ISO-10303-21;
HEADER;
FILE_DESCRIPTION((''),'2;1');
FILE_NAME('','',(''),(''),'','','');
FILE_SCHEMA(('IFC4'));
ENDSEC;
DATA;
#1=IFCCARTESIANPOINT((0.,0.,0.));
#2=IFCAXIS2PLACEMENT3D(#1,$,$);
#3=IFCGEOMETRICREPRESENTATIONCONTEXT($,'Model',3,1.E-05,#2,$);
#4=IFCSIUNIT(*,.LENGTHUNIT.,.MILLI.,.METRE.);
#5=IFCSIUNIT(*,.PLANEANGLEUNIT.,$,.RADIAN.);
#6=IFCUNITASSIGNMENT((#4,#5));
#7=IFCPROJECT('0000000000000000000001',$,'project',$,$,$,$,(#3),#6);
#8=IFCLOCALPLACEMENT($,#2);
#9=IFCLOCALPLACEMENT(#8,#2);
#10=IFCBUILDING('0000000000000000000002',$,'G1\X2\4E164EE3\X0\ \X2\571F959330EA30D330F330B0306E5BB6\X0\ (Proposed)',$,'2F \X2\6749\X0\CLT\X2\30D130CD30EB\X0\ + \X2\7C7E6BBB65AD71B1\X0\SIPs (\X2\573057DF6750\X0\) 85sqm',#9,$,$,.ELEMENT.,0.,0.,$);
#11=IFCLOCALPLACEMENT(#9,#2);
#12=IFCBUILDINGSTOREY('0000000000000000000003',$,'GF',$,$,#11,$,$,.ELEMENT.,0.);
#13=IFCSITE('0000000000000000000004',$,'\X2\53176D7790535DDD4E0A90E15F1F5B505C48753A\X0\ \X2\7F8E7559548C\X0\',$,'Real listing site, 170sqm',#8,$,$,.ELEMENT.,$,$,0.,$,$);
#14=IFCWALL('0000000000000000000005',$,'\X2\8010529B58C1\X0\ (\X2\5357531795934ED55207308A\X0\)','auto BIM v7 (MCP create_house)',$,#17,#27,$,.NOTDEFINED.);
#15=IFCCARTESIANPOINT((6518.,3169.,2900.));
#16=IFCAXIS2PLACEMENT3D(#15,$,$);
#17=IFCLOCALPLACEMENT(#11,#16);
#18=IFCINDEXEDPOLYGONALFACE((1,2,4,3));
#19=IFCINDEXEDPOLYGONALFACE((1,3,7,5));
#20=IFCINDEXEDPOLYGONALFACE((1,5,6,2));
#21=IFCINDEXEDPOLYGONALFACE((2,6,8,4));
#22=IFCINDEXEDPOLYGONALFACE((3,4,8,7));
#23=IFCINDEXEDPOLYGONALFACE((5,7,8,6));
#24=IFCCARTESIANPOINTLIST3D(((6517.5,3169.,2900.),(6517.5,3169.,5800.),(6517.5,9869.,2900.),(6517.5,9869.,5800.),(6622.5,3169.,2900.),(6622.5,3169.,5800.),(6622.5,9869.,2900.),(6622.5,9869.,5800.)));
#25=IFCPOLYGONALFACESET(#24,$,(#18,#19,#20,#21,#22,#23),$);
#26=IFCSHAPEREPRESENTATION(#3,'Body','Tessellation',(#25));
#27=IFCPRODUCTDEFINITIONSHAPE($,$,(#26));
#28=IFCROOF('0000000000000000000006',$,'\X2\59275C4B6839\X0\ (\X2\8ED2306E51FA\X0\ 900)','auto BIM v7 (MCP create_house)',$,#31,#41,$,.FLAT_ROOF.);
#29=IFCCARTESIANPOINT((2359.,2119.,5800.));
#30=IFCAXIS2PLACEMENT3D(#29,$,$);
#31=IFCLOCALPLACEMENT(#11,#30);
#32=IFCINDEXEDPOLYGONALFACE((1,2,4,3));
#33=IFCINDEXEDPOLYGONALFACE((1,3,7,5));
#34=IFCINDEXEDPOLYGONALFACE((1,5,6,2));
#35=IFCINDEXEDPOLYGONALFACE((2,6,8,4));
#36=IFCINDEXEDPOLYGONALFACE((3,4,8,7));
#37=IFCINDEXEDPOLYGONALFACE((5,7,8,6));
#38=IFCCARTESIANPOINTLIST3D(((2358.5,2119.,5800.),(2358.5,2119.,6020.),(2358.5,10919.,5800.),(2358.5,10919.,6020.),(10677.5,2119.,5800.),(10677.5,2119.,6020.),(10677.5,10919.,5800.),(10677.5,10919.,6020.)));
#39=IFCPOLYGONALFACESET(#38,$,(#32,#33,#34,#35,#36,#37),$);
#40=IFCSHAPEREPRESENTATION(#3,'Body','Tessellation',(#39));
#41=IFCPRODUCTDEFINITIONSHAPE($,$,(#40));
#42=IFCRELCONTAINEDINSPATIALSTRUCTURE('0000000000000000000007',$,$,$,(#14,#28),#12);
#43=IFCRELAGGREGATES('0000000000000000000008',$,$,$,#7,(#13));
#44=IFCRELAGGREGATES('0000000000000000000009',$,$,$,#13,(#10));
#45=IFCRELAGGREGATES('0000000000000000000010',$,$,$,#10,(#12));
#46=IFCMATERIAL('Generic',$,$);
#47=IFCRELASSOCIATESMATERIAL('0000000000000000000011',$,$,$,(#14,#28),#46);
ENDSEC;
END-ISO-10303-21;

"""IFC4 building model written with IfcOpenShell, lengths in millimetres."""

from ifc_helpers import new_model, si_unit, frame, frame_2d, origin, place, context, project, spatial, rectangle, extrude, material, element, save


model = new_model("IFC4")

# Units and contexts
model_context = context("Model", 3, precision=1e-05, world=origin())
ifc_project = project(units=[si_unit("LENGTHUNIT", "METRE", prefix="MILLI"), si_unit("PLANEANGLEUNIT", "RADIAN")], contexts=[model_context])

# Site, building, storey
site_placement = place(None, origin())
site = spatial("IfcSite", under=ifc_project, at=site_placement, Name="北海道川上郡弟子屈町 美留和", ObjectType="Real listing site, 170sqm", CompositionType="ELEMENT", RefElevation=0.0)
building_placement = place(site_placement, origin())
building = spatial("IfcBuilding", under=site, at=building_placement, Name="G1世代 土間リビングの家 (Proposed)", ObjectType="2F 杉CLTパネル + 籾殻断熱SIPs (地域材) 85sqm", CompositionType="ELEMENT", ElevationOfRefHeight=0.0, ElevationOfTerrain=0.0)
storey_placement = place(building_placement, origin())
storey = spatial("IfcBuildingStorey", under=building, at=storey_placement, Name="GF", CompositionType="ELEMENT", Elevation=0.0)

# Shared definitions
ifc_material = material(Name="Generic")

# Wall
wall_1_placement = place(storey_placement, frame((6518.0, 3169.0, 2900.0)))
element("IfcWall", 1, at=wall_1_placement, inside=storey, material=ifc_material, Name="耐力壁 (南北間仕切り)", Description="auto BIM v7 (MCP create_house)", PredefinedType="NOTDEFINED", context=model_context, shape_type="SweptSolid", body=[
    extrude(rectangle(XDim=105.0, YDim=6700.0, at=frame_2d((52.0, 3350.0))), frame((6518.0, 3169.0, 2900.0)), (0.0, 0.0, 1.0), 2900.0),
])

# Roof
roof_placement = place(storey_placement, frame((2359.0, 2119.0, 5800.0)))
element("IfcRoof", 2, at=roof_placement, inside=storey, material=ifc_material, Name="大屋根 (軒の出 900)", Description="auto BIM v7 (MCP create_house)", PredefinedType="FLAT_ROOF", context=model_context, shape_type="SweptSolid", body=[
    extrude(rectangle(XDim=8319.0, YDim=8800.0, at=frame_2d((4159.0, 4400.0))), frame((2359.0, 2119.0, 5800.0)), (0.0, 0.0, 1.0), 220.0),
])

save(model, "model.ifc")
